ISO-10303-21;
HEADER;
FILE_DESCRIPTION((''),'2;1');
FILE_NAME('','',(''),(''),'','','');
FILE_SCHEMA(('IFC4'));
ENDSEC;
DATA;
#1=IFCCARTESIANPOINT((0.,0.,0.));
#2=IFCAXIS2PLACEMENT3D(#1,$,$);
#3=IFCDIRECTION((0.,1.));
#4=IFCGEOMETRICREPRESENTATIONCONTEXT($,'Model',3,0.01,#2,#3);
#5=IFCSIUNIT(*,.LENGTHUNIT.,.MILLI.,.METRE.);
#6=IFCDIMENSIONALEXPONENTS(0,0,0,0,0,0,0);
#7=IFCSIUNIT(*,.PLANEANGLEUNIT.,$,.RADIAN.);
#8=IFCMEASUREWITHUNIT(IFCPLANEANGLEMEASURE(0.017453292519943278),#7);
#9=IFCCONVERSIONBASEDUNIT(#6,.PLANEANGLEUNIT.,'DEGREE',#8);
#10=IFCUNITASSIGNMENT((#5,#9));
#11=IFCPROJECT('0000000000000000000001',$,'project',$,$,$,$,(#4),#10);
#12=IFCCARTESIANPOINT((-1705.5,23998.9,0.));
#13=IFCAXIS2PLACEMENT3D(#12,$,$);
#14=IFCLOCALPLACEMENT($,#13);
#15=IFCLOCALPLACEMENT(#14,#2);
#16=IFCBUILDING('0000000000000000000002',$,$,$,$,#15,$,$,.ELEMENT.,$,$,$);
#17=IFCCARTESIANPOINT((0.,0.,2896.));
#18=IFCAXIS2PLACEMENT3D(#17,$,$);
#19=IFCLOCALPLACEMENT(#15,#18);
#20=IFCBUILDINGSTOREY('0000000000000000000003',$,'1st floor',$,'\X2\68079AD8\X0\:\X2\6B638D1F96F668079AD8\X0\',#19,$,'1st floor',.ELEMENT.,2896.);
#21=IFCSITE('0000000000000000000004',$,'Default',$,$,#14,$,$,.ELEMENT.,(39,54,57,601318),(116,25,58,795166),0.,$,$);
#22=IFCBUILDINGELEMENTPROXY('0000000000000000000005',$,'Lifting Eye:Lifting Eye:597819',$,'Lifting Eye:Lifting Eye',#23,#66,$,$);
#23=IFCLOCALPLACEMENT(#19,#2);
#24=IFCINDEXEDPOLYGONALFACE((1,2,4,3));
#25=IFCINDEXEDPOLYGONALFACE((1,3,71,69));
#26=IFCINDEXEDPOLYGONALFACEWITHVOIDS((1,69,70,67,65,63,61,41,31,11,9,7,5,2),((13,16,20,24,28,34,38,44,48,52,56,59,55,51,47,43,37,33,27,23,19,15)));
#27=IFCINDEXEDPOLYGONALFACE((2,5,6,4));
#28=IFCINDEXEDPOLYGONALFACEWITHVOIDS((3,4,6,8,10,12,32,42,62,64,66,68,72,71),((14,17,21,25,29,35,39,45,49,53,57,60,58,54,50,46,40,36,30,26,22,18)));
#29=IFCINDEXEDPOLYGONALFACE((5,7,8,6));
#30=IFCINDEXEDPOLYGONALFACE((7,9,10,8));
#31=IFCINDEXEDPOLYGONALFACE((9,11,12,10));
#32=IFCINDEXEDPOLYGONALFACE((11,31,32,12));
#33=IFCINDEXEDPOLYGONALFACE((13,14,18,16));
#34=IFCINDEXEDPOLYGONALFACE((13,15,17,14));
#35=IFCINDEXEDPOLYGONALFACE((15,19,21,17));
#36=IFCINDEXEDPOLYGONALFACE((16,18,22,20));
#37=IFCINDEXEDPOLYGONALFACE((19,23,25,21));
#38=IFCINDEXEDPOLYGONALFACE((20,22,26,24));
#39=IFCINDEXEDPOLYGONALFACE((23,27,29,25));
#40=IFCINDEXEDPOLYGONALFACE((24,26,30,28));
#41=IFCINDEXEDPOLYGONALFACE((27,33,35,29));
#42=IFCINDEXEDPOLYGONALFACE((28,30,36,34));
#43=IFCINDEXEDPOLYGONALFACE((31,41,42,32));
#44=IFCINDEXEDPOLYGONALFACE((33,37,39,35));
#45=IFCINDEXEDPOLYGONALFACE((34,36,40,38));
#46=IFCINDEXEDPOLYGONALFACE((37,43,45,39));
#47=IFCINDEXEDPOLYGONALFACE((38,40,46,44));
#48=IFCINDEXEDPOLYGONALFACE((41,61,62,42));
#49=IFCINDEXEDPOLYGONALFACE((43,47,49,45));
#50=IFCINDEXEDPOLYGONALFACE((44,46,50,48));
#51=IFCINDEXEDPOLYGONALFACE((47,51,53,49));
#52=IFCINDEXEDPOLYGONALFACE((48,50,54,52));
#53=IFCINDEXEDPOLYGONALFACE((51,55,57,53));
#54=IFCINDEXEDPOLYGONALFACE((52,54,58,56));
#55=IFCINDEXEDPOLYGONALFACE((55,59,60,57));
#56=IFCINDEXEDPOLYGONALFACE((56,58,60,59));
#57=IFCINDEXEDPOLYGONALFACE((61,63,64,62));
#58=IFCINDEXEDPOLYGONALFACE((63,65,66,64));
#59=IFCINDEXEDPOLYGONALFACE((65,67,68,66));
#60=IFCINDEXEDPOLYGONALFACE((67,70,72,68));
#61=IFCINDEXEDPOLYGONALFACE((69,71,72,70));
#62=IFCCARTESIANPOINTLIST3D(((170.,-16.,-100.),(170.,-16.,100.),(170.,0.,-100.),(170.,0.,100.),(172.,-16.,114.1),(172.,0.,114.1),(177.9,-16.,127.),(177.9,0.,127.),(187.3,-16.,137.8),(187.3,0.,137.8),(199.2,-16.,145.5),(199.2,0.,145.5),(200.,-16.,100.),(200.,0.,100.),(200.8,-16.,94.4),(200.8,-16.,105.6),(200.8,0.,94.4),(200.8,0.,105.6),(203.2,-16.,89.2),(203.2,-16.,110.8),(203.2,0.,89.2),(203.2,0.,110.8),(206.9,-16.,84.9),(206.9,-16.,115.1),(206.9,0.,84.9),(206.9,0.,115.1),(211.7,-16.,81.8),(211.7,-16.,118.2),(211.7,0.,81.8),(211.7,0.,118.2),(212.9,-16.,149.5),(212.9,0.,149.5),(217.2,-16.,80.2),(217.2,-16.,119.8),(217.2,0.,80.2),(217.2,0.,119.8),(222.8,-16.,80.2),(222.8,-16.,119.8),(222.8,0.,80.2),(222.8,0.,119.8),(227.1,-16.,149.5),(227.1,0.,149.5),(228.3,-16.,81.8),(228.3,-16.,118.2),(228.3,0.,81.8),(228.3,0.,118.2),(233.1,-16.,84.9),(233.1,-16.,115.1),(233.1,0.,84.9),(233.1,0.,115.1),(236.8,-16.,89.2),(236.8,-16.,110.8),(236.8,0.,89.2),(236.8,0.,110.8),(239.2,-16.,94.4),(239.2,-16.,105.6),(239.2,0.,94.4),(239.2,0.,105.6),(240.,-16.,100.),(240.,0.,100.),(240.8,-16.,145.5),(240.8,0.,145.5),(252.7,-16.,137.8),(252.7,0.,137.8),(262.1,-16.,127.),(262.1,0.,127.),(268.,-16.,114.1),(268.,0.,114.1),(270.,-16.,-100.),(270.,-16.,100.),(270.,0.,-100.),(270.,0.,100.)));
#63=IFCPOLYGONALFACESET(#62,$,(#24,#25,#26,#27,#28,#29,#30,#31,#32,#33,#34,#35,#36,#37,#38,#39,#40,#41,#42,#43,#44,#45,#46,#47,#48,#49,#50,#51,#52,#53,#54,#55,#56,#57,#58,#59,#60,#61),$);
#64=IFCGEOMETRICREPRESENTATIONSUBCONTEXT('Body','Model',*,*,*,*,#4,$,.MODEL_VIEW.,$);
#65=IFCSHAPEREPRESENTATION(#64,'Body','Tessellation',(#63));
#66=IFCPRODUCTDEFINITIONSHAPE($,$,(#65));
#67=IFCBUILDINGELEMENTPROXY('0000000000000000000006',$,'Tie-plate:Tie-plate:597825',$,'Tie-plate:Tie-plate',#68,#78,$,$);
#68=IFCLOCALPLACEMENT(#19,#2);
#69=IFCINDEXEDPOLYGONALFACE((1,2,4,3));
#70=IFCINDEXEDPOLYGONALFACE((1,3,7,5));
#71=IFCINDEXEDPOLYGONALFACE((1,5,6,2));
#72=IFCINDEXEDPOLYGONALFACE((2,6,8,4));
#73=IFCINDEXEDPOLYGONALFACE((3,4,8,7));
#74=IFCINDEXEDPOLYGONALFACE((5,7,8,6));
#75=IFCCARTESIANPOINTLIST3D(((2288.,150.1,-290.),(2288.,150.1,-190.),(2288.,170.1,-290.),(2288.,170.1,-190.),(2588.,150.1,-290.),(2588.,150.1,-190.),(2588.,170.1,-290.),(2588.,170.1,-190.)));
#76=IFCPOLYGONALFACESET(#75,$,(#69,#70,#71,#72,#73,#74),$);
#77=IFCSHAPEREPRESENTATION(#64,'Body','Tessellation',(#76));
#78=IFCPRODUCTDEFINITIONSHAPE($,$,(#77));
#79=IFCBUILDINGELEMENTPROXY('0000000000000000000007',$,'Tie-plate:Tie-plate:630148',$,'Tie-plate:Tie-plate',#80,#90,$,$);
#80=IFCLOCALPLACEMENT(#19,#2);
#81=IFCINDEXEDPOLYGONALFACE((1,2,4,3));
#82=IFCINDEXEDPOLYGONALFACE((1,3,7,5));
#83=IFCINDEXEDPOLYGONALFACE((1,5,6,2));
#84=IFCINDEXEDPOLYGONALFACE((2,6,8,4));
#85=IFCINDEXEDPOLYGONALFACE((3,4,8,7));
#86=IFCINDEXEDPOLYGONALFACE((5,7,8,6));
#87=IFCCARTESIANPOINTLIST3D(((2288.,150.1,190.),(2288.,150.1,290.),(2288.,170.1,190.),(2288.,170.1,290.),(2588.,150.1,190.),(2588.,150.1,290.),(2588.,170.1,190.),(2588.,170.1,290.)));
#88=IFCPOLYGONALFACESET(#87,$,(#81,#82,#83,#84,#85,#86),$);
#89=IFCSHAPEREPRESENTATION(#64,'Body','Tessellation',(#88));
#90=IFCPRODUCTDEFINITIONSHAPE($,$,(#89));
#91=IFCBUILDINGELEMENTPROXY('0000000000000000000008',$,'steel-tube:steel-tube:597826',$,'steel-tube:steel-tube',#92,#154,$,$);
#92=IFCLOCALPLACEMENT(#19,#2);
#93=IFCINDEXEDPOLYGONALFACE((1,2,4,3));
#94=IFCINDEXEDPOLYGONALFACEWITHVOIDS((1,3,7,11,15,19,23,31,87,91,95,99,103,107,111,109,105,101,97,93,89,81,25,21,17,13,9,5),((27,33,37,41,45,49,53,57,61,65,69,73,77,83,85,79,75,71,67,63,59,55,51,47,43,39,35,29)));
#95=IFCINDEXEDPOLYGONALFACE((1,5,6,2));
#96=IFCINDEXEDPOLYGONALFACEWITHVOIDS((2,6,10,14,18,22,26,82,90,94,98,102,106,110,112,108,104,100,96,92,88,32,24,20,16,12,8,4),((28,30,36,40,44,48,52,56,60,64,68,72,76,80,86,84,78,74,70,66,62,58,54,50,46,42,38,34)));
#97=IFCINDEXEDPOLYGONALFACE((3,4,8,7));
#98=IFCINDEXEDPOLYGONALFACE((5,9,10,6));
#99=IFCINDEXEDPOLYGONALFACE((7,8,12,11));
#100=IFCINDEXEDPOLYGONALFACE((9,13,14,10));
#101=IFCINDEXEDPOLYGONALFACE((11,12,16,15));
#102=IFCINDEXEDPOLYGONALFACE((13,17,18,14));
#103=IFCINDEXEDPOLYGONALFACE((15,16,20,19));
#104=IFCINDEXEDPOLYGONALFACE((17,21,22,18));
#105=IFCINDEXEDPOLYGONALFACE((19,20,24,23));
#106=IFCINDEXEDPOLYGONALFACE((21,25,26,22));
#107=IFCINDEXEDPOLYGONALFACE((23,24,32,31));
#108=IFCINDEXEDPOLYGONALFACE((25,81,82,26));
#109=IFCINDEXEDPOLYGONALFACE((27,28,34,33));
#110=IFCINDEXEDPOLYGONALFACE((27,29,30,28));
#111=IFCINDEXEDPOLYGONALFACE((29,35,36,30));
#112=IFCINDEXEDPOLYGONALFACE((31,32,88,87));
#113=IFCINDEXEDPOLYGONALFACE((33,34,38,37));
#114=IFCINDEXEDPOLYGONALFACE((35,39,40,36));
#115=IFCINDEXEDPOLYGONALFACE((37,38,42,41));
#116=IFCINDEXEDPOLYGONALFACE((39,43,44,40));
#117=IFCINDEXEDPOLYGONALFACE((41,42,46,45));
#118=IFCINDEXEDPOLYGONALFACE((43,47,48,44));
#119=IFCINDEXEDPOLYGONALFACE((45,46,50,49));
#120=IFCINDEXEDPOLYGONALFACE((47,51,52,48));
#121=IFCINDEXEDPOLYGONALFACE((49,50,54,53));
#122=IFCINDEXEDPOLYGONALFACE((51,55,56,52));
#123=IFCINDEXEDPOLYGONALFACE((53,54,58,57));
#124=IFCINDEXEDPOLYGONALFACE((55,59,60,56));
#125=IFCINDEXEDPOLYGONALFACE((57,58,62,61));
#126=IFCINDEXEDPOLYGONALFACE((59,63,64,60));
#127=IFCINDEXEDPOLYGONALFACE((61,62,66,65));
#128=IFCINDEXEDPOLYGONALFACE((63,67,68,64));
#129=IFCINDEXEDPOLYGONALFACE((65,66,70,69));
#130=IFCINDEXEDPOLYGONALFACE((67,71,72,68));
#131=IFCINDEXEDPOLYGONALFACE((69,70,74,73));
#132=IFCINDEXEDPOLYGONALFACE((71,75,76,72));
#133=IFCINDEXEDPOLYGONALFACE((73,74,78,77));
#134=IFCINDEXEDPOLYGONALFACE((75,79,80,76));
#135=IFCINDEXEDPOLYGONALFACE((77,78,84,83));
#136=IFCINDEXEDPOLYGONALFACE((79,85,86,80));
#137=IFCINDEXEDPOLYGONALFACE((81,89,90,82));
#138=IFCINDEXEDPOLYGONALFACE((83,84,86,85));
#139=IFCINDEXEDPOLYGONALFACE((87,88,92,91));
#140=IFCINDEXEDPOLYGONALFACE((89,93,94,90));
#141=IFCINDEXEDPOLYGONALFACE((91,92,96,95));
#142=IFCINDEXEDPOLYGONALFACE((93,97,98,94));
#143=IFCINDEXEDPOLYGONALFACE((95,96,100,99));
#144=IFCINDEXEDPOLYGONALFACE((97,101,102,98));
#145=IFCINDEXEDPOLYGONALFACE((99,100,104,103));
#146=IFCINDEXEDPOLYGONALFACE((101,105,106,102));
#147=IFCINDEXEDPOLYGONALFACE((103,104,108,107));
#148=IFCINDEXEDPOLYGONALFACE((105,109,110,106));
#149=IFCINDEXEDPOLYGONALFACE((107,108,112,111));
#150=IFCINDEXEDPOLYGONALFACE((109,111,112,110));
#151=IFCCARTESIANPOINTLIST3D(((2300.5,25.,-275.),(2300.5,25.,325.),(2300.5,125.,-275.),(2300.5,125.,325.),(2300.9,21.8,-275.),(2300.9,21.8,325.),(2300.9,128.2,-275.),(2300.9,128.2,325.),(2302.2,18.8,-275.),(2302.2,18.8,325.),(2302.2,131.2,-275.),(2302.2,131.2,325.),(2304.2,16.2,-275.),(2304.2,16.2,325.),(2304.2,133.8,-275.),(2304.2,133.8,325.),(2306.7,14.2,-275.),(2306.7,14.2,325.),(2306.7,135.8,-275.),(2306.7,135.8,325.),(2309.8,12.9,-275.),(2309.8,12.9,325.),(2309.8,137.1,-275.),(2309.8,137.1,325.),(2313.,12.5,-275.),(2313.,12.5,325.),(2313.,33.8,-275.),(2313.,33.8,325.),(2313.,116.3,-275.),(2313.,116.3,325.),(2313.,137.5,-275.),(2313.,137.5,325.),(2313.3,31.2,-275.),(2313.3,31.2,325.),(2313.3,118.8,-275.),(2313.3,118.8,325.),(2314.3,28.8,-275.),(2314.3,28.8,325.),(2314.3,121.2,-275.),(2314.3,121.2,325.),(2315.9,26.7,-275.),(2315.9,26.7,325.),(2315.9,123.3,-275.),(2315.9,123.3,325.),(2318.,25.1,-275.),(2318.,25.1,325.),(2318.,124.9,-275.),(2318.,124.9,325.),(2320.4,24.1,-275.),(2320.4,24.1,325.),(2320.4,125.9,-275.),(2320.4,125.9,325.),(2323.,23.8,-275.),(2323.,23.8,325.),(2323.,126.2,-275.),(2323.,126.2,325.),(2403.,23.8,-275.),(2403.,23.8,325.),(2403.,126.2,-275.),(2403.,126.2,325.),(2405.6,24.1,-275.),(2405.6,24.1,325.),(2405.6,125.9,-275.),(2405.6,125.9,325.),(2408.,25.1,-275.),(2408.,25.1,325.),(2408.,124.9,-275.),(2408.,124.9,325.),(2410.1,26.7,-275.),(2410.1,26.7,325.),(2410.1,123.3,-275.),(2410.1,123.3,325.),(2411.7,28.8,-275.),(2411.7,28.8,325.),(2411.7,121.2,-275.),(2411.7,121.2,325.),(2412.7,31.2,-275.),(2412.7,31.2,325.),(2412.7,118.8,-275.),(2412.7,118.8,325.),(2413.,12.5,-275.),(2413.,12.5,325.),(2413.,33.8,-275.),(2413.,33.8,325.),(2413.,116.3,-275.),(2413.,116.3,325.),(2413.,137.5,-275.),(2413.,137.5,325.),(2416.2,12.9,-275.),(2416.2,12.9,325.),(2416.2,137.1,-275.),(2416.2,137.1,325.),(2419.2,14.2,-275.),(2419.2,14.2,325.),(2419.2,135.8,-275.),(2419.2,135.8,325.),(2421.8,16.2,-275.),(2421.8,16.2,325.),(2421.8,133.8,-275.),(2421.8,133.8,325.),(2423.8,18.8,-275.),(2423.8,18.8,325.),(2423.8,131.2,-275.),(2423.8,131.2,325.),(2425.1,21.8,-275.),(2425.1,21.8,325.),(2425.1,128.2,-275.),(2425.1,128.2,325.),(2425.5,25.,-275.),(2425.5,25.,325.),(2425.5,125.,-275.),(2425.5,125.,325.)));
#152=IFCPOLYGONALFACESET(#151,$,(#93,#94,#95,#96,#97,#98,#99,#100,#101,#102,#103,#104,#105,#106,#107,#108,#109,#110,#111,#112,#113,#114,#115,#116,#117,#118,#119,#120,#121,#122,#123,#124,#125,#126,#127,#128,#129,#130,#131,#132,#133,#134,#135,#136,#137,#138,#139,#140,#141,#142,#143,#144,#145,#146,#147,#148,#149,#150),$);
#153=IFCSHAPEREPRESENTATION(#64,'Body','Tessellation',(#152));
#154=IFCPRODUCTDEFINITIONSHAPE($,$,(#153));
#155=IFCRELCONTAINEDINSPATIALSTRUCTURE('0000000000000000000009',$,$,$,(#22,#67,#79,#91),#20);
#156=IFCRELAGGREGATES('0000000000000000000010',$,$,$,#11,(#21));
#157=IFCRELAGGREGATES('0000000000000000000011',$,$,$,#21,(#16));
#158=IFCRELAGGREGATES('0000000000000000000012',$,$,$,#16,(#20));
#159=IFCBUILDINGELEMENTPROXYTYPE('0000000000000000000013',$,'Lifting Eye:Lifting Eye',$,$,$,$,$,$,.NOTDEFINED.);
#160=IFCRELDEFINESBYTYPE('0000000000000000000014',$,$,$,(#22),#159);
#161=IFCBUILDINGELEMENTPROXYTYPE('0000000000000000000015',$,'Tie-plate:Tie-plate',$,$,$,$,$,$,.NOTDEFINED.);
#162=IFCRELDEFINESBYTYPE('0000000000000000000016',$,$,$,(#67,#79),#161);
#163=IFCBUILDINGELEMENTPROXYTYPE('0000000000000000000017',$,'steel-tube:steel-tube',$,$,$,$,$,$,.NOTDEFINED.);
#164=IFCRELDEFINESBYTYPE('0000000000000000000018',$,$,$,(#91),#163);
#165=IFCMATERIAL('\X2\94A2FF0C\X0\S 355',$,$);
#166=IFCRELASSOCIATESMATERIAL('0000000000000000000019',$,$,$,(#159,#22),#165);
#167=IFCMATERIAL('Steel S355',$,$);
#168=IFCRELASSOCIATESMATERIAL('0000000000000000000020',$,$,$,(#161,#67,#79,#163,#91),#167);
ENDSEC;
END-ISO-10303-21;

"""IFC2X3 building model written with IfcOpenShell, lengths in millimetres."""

from ifc_helpers import new_model, entity, si_unit, converted_unit, direction, frame, frame_2d, origin, place, context, subcontext, project, spatial, polyline, circle_curve, parameter, trimmed, segment, composite_curve, rectangle, outline, extrude, source, transform, mapped, material, type_object, type_shapes, element, save


model = new_model("IFC2X3")

# Units and contexts
model_context = context("Model", 3, precision=0.01, world=origin(), true_north=direction((0.0, 1.0)))
body_context = subcontext(model_context, "Body", "Model", "MODEL_VIEW")
ifc_project = project(units=[si_unit("LENGTHUNIT", "METRE", prefix="MILLI"), converted_unit("PLANEANGLEUNIT", "DEGREE", entity("IfcPlaneAngleMeasure", 0.017453292519943278), si_unit("PLANEANGLEUNIT", "RADIAN"), dimensions=[0, 0, 0, 0, 0, 0, 0])], contexts=[model_context])

# Site, building, storey
site_placement = place(None, frame((-1705.5, 23998.9, 0.0)))
site = spatial("IfcSite", under=ifc_project, at=site_placement, Name="Default", CompositionType="ELEMENT", RefLatitude=(39, 54, 57, 601318), RefLongitude=(116, 25, 58, 795166), RefElevation=0.0)
building_placement = place(site_placement, origin())
building = spatial("IfcBuilding", under=site, at=building_placement, CompositionType="ELEMENT")
storey_placement = place(building_placement, frame((0.0, 0.0, 2896.0)))
storey = spatial("IfcBuildingStorey", under=building, at=storey_placement, Name="1st floor", ObjectType="标高:正负零标高", LongName="1st floor", CompositionType="ELEMENT", Elevation=2896.0)

# Shared definitions
ifc_material_1 = material(Name="Steel S355")

# Building element proxies
ifc_material_2 = material(Name="钢，S 355")
building_element_proxy_type_1 = type_object("IfcBuildingElementProxyType", Name="Lifting Eye:Lifting Eye", PredefinedType="NOTDEFINED", material=ifc_material_2)
shared_shape_1 = source(origin(), body_context, "Body", "SweptSolid", [
    extrude(outline(composite_curve([segment(polyline([(-100.0, -50.0), (100.0, -50.0)]), True, "CONTINUOUS"), segment(polyline([(100.0, -50.0), (100.0, 50.0)]), True, "CONTINUOUS"), segment(polyline([(100.0, 50.0), (-100.0, 50.0)]), True, "CONTINUOUS"), segment(trimmed(circle_curve(frame_2d((-100.0, 0.0), x_axis=(0.0, -1.0)), 50.0), [parameter(180.0)], [parameter(0.0)], True, "PARAMETER"), True, "CONTINUOUS")], self_intersect=False), holes=[composite_curve([segment(trimmed(circle_curve(frame_2d((-100.0, 0.0), x_axis=(0.0, -1.0)), 20.0), [parameter(180.0)], [parameter(360.0)], True, "PARAMETER"), False, "CONTINUOUS"), segment(trimmed(circle_curve(frame_2d((-100.0, 0.0), x_axis=(0.0, -1.0)), 20.0), [parameter(0.0)], [parameter(180.0)], True, "PARAMETER"), False, "CONTINUOUS")], self_intersect=False)]), frame((0.0, 17.0, -17.0), z_axis=(0.0, 1.0, 0.0), x_axis=(0.0, 0.0, -1.0)), (0.0, 0.0, 1.0), 16.0),
])
type_shapes(building_element_proxy_type_1, [shared_shape_1])
for number, where, name in (
    (1, (220.0, -33.0, 17.0), "Lifting Eye:Lifting Eye:597819"),
):
    element("IfcBuildingElementProxy", number, at=place(storey_placement, frame(where)), inside=storey, type_object=building_element_proxy_type_1, material=ifc_material_2, Name=name, ObjectType="Lifting Eye:Lifting Eye", context=body_context, shape_type="MappedRepresentation", body=[
        mapped(shared_shape_1, transform((0.0, 0.0, 0.0), scale=1.0)),
    ])
building_element_proxy_type_2 = type_object("IfcBuildingElementProxyType", Name="Tie-plate:Tie-plate", PredefinedType="NOTDEFINED", material=ifc_material_1)
shared_shape_2 = source(origin(), body_context, "Body", "SweptSolid", [
    extrude(rectangle(XDim=20.0, YDim=300.0, at=frame_2d((0.0, 0.0), x_axis=(1.0, 0.0))), frame((150.0, 10.0, 0.0), z_axis=(0.0, 0.0, 1.0), x_axis=(0.0, 1.0, 0.0)), (0.0, 0.0, 1.0), 100.0),
])
type_shapes(building_element_proxy_type_2, [shared_shape_2])
for number, where, name in (
    (2, (2288.0, 150.1, -290.0), "Tie-plate:Tie-plate:597825"),
    (3, (2288.0, 150.1, 190.0), "Tie-plate:Tie-plate:630148"),
):
    element("IfcBuildingElementProxy", number, at=place(storey_placement, frame(where)), inside=storey, type_object=building_element_proxy_type_2, material=ifc_material_1, Name=name, ObjectType="Tie-plate:Tie-plate", context=body_context, shape_type="MappedRepresentation", body=[
        mapped(shared_shape_2, transform((0.0, 0.0, 0.0), scale=1.0)),
    ])
building_element_proxy_type_3 = type_object("IfcBuildingElementProxyType", Name="steel-tube:steel-tube", PredefinedType="NOTDEFINED", material=ifc_material_1)
shared_shape_3 = source(origin(), body_context, "Body", "SweptSolid", [
    extrude(outline(composite_curve([segment(trimmed(circle_curve(frame_2d((50.0, -50.0), x_axis=(1.0, 0.0)), 12.5), [parameter(270.0)], [parameter(0.0)], True, "PARAMETER"), True, "CONTINUOUS"), segment(polyline([(62.5, -50.0), (62.5, 50.0)]), True, "CONTINUOUS"), segment(trimmed(circle_curve(frame_2d((50.0, 50.0), x_axis=(1.0, 0.0)), 12.5), [parameter(0.0)], [parameter(90.0)], True, "PARAMETER"), True, "CONTINUOUS"), segment(polyline([(50.0, 62.5), (-50.0, 62.5)]), True, "CONTINUOUS"), segment(trimmed(circle_curve(frame_2d((-50.0, 50.0), x_axis=(1.0, 0.0)), 12.5), [parameter(90.0)], [parameter(180.0)], True, "PARAMETER"), True, "CONTINUOUS"), segment(polyline([(-62.5, 50.0), (-62.5, -50.0)]), True, "CONTINUOUS"), segment(trimmed(circle_curve(frame_2d((-50.0, -50.0), x_axis=(1.0, 0.0)), 12.5), [parameter(180.0)], [parameter(270.0)], True, "PARAMETER"), True, "CONTINUOUS"), segment(polyline([(-50.0, -62.5), (50.0, -62.5)]), True, "CONTINUOUS")], self_intersect=False), holes=[composite_curve([segment(trimmed(circle_curve(frame_2d((-41.2, 40.0), x_axis=(1.0, 0.0)), 10.0), [parameter(90.0)], [parameter(180.0)], True, "PARAMETER"), False, "CONTINUOUS"), segment(polyline([(-41.3, 50.0), (41.2, 50.0)]), True, "CONTINUOUS"), segment(trimmed(circle_curve(frame_2d((41.2, 40.0), x_axis=(1.0, 0.0)), 10.0), [parameter(0.0)], [parameter(90.0)], True, "PARAMETER"), False, "CONTINUOUS"), segment(polyline([(51.2, 40.0), (51.2, -40.0)]), True, "CONTINUOUS"), segment(trimmed(circle_curve(frame_2d((41.2, -40.0), x_axis=(1.0, 0.0)), 10.0), [parameter(270.0)], [parameter(360.0)], True, "PARAMETER"), False, "CONTINUOUS"), segment(polyline([(41.2, -50.0), (-41.3, -50.0)]), True, "CONTINUOUS"), segment(trimmed(circle_curve(frame_2d((-41.3, -40.0), x_axis=(1.0, 0.0)), 10.0), [parameter(180.0)], [parameter(270.0)], True, "PARAMETER"), False, "CONTINUOUS"), segment(polyline([(-51.3, -40.0), (-51.3, 40.0)]), True, "CONTINUOUS")], self_intersect=False)]), frame((62.5, 62.5, -175.0)), (0.0, 0.0, 1.0), 600.0),
])
type_shapes(building_element_proxy_type_3, [shared_shape_3])
for number, where, z_axis, x_axis, name in (
    (4, (2300.5, 137.5, -100.0), (0.0, 0.0, 1.0), (0.0, -1.0, 0.0), "steel-tube:steel-tube:597826"),
):
    element("IfcBuildingElementProxy", number, at=place(storey_placement, frame(where, z_axis=z_axis, x_axis=x_axis)), inside=storey, type_object=building_element_proxy_type_3, material=ifc_material_1, Name=name, ObjectType="steel-tube:steel-tube", context=body_context, shape_type="MappedRepresentation", body=[
        mapped(shared_shape_3, transform((0.0, 0.0, 0.0), scale=1.0)),
    ])

save(model, "model.ifc")
